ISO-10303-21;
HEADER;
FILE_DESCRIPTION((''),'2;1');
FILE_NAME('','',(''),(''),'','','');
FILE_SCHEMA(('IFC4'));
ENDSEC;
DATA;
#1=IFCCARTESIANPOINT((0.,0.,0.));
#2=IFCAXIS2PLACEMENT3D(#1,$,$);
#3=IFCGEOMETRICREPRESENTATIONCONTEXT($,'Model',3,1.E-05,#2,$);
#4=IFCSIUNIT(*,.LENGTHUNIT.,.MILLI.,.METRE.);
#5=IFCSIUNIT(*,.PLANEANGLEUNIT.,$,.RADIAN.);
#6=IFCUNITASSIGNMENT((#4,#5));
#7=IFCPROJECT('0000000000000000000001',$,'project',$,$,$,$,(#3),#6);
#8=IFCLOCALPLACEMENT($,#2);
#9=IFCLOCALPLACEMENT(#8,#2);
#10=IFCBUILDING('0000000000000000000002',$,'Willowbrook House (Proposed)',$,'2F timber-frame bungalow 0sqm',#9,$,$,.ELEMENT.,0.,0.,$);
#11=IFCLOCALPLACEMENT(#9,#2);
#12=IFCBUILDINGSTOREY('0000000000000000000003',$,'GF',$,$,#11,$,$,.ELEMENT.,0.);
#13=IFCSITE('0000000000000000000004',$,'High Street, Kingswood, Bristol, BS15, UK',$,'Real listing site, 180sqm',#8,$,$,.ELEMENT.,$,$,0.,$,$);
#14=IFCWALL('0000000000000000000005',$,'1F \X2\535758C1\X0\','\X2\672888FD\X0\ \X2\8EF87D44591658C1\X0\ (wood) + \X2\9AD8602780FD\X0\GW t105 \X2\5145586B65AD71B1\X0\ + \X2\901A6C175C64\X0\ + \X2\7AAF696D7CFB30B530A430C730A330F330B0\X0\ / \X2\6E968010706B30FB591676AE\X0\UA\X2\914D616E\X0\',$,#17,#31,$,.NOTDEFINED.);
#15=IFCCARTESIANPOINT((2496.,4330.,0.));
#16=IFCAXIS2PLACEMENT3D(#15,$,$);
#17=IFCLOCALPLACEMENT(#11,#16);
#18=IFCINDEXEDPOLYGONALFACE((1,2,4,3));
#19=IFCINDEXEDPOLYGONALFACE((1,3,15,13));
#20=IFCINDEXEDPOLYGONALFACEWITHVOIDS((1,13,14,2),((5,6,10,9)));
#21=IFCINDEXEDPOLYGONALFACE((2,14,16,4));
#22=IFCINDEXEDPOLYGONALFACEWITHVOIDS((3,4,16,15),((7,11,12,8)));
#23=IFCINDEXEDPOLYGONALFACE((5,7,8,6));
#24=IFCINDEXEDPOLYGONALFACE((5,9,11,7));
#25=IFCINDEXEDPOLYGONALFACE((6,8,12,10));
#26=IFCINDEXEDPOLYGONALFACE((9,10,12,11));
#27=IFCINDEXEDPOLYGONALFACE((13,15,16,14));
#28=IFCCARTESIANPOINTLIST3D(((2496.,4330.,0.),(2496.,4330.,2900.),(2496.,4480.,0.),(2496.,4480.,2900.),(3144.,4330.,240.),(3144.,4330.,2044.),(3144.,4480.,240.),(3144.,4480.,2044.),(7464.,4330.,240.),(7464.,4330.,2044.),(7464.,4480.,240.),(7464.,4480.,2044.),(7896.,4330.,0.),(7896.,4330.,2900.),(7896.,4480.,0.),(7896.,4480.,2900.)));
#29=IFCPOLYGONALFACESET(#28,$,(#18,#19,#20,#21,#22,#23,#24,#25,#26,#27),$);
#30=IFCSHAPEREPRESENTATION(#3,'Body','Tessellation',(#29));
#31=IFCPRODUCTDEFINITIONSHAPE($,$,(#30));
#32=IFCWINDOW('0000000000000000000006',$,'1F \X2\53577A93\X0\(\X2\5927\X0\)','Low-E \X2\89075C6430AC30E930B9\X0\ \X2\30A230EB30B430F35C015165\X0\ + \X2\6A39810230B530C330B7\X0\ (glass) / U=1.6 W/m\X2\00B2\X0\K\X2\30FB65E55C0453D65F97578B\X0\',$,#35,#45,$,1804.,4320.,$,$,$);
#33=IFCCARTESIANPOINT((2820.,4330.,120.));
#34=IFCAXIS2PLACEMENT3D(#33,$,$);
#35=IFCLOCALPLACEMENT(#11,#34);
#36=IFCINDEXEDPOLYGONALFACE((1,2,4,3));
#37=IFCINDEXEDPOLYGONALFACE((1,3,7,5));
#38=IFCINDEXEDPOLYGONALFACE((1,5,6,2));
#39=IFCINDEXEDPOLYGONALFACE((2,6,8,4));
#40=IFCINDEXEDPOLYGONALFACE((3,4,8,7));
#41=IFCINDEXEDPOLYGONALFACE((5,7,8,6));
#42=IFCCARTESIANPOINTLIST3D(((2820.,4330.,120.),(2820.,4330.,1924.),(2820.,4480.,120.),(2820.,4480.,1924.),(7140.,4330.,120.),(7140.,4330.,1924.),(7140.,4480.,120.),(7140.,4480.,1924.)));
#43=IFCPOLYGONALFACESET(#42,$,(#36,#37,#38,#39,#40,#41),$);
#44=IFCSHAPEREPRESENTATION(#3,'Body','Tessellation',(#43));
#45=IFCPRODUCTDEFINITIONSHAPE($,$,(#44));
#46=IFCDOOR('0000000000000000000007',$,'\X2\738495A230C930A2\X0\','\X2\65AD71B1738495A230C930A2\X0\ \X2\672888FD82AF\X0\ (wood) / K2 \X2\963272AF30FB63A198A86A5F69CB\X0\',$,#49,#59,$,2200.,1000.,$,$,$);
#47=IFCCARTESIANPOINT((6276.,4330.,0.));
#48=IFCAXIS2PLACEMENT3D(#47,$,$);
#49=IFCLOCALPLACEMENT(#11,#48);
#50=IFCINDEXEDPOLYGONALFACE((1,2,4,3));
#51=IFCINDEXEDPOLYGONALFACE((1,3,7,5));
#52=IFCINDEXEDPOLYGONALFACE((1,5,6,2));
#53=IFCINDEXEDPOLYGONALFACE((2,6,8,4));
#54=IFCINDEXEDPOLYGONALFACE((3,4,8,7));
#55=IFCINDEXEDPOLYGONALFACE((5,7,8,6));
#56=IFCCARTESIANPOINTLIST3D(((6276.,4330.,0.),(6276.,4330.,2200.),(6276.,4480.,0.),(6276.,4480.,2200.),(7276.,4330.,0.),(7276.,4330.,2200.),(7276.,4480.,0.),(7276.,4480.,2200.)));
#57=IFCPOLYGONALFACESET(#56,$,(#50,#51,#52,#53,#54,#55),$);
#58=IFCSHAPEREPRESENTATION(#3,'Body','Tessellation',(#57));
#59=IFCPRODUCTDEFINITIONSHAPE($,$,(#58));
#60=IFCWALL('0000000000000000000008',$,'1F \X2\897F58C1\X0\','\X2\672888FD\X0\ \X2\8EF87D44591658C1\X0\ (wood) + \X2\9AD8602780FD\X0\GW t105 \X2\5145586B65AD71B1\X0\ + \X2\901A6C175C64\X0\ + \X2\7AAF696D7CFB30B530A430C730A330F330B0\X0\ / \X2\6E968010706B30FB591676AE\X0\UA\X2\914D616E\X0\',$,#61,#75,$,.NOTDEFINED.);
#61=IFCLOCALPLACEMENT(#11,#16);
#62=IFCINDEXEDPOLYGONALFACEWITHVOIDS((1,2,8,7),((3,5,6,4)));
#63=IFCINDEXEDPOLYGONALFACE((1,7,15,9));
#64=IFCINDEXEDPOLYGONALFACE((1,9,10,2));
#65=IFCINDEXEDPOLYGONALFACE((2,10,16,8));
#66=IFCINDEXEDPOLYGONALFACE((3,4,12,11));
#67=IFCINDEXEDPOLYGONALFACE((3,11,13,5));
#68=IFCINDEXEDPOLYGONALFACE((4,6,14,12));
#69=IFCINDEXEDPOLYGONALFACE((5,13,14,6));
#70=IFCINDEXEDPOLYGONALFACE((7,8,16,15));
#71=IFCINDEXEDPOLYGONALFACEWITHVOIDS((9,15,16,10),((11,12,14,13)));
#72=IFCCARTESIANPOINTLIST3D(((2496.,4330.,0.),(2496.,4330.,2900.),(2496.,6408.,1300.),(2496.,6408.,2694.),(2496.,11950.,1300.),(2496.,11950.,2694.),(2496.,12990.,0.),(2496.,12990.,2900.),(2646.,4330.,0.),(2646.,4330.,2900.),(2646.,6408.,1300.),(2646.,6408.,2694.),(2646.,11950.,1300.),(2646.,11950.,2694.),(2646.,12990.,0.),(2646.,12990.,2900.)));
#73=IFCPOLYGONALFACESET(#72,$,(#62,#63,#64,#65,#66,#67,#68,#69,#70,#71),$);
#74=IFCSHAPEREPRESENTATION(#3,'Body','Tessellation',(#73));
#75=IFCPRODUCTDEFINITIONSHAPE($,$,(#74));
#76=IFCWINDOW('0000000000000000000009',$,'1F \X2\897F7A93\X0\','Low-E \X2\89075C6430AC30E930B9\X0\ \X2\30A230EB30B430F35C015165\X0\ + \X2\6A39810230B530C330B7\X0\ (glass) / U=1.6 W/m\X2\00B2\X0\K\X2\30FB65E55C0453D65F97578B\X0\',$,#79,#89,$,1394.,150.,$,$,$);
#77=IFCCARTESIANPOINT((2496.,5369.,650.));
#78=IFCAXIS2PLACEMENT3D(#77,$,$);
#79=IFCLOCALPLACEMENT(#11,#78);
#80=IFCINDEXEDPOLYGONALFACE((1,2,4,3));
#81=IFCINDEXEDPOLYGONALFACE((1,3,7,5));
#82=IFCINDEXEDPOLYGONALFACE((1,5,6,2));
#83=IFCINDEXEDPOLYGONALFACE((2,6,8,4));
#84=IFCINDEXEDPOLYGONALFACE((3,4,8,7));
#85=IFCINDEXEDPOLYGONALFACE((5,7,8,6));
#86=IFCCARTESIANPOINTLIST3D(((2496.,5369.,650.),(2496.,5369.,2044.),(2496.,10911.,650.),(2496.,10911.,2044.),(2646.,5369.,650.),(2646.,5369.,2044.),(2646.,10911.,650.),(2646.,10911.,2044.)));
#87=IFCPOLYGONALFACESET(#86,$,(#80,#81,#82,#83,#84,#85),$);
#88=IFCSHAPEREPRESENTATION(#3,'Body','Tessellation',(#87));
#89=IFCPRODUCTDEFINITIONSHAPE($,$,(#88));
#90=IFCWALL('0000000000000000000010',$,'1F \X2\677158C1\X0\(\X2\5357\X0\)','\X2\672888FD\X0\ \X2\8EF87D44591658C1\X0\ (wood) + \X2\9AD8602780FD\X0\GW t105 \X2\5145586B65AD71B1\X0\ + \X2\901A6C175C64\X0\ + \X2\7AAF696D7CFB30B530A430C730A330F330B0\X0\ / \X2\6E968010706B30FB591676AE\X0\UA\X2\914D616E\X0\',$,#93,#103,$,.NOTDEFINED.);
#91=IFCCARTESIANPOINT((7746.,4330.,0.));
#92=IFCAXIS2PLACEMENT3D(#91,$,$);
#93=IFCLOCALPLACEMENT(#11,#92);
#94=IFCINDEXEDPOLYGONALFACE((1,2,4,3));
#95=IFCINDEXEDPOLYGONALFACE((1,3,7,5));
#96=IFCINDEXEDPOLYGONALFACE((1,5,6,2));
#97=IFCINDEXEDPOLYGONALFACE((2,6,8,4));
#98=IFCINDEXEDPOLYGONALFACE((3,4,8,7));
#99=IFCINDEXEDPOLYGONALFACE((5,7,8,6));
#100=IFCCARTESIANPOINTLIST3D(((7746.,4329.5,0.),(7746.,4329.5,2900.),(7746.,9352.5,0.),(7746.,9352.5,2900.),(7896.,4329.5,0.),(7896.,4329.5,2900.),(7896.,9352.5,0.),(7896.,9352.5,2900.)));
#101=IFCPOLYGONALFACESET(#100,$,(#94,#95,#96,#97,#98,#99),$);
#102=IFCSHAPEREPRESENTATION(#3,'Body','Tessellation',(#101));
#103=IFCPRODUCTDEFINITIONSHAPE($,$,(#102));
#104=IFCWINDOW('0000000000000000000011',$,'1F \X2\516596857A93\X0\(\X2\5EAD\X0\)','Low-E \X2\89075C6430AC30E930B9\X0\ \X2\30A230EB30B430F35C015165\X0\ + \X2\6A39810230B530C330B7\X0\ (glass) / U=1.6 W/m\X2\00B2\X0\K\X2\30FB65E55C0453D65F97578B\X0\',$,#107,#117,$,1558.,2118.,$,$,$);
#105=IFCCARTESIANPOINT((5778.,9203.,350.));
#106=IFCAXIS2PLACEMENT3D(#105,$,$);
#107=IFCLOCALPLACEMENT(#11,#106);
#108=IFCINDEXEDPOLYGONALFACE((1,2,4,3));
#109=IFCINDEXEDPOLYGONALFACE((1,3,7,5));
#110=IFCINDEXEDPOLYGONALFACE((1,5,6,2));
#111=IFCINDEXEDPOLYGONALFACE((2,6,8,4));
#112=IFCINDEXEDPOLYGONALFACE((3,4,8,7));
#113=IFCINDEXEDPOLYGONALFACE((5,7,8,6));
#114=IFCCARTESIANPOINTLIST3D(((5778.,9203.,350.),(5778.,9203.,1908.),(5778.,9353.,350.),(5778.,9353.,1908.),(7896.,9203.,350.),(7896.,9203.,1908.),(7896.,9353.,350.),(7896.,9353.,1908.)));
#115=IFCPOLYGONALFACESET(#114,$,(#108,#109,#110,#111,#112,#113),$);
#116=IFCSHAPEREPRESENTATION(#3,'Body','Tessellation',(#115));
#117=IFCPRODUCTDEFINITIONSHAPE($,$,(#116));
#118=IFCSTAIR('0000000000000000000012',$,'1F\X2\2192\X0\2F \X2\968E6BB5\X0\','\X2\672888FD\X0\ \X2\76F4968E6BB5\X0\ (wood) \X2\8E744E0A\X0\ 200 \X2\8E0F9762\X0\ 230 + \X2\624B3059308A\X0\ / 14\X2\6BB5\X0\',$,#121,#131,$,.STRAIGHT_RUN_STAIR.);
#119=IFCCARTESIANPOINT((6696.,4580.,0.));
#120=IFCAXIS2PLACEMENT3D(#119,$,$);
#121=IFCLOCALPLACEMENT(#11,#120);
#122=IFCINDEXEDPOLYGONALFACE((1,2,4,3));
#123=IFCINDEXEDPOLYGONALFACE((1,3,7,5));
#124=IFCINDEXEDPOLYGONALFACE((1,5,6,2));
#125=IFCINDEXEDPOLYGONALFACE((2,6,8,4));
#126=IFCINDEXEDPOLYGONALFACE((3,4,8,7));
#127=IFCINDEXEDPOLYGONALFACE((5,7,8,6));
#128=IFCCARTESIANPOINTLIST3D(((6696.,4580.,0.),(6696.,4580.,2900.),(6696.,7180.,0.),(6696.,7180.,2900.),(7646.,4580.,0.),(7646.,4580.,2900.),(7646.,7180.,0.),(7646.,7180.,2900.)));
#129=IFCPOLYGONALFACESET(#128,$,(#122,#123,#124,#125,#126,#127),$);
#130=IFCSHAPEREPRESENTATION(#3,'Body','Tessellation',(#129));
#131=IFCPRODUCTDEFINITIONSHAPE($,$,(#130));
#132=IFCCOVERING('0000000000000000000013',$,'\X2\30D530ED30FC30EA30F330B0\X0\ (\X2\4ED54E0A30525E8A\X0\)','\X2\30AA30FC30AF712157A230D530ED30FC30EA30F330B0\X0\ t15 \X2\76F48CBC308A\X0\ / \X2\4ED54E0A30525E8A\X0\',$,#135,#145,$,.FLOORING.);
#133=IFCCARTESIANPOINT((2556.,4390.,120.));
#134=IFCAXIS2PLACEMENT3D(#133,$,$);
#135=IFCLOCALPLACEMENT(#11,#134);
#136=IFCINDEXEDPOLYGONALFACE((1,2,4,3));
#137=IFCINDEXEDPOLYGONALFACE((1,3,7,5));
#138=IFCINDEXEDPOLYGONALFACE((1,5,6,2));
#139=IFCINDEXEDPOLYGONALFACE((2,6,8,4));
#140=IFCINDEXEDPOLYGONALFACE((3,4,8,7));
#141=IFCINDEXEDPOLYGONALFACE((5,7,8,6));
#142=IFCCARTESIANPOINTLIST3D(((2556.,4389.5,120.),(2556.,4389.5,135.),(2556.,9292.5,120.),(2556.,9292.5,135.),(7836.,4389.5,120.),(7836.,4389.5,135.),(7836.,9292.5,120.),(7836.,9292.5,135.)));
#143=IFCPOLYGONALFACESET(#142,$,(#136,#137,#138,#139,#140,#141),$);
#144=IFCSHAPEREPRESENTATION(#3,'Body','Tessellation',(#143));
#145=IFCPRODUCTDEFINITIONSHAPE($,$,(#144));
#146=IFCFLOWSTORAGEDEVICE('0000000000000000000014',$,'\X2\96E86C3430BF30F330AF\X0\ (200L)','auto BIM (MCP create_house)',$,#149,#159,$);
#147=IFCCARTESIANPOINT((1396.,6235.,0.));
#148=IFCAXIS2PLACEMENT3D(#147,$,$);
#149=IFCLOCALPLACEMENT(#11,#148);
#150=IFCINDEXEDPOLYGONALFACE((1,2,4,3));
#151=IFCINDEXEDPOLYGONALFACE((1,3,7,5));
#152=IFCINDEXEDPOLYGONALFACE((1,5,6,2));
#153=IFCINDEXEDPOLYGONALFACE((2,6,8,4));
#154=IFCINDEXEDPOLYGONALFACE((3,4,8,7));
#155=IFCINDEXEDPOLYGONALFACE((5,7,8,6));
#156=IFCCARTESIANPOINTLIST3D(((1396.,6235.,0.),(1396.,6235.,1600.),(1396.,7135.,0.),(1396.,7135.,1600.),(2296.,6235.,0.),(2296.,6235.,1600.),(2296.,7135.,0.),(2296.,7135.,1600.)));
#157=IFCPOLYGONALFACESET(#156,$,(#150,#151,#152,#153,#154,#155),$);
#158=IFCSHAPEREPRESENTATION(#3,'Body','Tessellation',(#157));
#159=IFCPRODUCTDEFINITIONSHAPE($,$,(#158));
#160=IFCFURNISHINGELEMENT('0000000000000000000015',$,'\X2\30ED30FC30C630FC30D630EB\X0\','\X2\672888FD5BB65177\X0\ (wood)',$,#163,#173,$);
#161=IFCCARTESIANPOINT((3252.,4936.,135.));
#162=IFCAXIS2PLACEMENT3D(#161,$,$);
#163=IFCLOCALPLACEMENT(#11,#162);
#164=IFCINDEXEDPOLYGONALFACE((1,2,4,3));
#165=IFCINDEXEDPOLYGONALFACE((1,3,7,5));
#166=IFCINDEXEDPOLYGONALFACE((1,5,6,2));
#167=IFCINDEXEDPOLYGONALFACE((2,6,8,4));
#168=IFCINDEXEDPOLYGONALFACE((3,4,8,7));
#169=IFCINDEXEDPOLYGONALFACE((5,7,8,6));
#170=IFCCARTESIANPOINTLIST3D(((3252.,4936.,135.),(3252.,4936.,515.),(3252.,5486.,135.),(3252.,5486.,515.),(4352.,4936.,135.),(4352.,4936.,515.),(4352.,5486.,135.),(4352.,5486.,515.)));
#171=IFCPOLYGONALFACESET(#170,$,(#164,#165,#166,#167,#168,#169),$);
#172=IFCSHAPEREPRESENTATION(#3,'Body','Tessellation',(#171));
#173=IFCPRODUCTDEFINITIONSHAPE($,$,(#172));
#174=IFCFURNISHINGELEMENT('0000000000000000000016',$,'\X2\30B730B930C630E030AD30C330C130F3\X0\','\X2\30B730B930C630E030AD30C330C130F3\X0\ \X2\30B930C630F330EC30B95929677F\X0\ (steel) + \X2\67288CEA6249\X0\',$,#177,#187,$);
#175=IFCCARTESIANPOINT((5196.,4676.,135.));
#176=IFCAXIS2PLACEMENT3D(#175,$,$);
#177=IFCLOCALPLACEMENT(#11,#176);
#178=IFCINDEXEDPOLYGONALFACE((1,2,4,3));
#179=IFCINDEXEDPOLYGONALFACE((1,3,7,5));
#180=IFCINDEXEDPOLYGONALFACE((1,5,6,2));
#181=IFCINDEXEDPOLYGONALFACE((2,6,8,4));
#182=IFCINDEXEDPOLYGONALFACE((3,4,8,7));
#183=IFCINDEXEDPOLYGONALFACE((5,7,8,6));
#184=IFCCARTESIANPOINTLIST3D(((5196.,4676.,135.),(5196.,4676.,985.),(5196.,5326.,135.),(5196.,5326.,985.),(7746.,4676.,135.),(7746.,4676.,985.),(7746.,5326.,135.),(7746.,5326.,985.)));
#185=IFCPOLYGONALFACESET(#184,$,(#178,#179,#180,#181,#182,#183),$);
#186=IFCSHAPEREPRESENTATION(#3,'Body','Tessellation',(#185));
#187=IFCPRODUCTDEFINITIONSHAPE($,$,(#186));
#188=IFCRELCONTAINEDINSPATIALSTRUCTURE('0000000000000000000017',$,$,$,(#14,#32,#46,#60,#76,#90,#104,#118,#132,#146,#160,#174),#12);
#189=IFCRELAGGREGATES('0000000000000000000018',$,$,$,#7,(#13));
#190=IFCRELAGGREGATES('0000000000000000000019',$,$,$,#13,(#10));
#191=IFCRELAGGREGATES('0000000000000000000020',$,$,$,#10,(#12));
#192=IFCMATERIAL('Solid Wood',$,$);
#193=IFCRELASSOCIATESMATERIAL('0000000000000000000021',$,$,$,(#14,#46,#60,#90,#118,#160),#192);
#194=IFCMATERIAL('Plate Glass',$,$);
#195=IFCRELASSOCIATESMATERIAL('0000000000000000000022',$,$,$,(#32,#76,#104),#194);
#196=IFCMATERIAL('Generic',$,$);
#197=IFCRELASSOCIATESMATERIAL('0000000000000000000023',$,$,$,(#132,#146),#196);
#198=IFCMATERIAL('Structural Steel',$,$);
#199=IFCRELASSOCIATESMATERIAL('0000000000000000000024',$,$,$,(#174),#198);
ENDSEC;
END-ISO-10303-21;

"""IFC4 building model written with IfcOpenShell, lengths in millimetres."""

from ifc_helpers import new_model, si_unit, frame, frame_2d, origin, place, context, project, spatial, rectangle, extrude, material, element, fill, save


model = new_model("IFC4")

# Units and contexts
model_context = context("Model", 3, precision=1e-05, world=origin())
ifc_project = project(units=[si_unit("LENGTHUNIT", "METRE", prefix="MILLI"), si_unit("PLANEANGLEUNIT", "RADIAN")], contexts=[model_context])

# Site, building, storey
site_placement = place(None, origin())
site = spatial("IfcSite", under=ifc_project, at=site_placement, Name="High Street, Kingswood, Bristol, BS15, UK", ObjectType="Real listing site, 180sqm", CompositionType="ELEMENT", RefElevation=0.0)
building_placement = place(site_placement, origin())
building = spatial("IfcBuilding", under=site, at=building_placement, Name="Willowbrook House (Proposed)", ObjectType="2F timber-frame bungalow 0sqm", CompositionType="ELEMENT", ElevationOfRefHeight=0.0, ElevationOfTerrain=0.0)
storey_placement = place(building_placement, origin())
storey = spatial("IfcBuildingStorey", under=building, at=storey_placement, Name="GF", CompositionType="ELEMENT", Elevation=0.0)

# Shared definitions
ifc_material_1 = material(Name="Solid Wood")

# Wall, openings, window, door
wall_1_placement = place(storey_placement, frame((2496.0, 4330.0, 0.0)))
wall_1 = element("IfcWall", 1, at=wall_1_placement, inside=storey, material=ifc_material_1, Name="1F 南壁", Description="木製 軸組外壁 (wood) + 高性能GW t105 充填断熱 + 通気層 + 窯業系サイディング / 準耐火・外皮UA配慮", PredefinedType="NOTDEFINED", context=model_context, shape_type="SweptSolid", body=[
    extrude(rectangle(XDim=5400.0, YDim=150.0, at=frame_2d((2700.0, 75.0))), frame((2496.0, 4330.0, 0.0)), (0.0, 0.0, 1.0), 2900.0),
])
opening_1_placement = place(storey_placement, frame((2820.0, 4330.0, 120.0)))
opening_1 = element("IfcOpeningElement", 2, at=opening_1_placement, cuts=wall_1, PredefinedType="NOTDEFINED", context=model_context, shape_type="SweptSolid", body=[
    extrude(rectangle(XDim=4320.0, YDim=150.0, at=frame_2d((2160.0, 75.0))), frame((2820.0, 4330.0, 120.0)), (0.0, 0.0, 1.0), 1804.0),
])
opening_2_placement = place(storey_placement, frame((6276.0, 4330.0, 0.0)))
opening_2 = element("IfcOpeningElement", 3, at=opening_2_placement, cuts=wall_1, PredefinedType="NOTDEFINED", context=model_context, shape_type="SweptSolid", body=[
    extrude(rectangle(XDim=1000.0, YDim=150.0, at=frame_2d((500.0, 75.0))), frame((6276.0, 4330.0, 0.0)), (0.0, 0.0, 1.0), 2200.0),
])
ifc_material_2 = material(Name="Plate Glass")
window_1_placement = place(storey_placement, frame((2820.0, 4330.0, 120.0)))
window_1 = element("IfcWindow", 4, at=window_1_placement, inside=storey, material=ifc_material_2, Name="1F 南窓(大)", Description="Low-E 複層ガラス アルゴン封入 + 樹脂サッシ (glass) / U=1.6 W/m²K・日射取得型", OverallHeight=1804.0, OverallWidth=4320.0, context=model_context, shape_type="SweptSolid", body=[
    extrude(rectangle(XDim=4320.0, YDim=150.0, at=frame_2d((2160.0, 75.0))), frame((2820.0, 4330.0, 120.0)), (0.0, 0.0, 1.0), 1804.0),
])
fill(opening_1, window_1)
door_1_placement = place(storey_placement, frame((6276.0, 4330.0, 0.0)))
door_1 = element("IfcDoor", 5, at=door_1_placement, inside=storey, material=ifc_material_1, Name="玄関ドア", Description="断熱玄関ドア 木製芯 (wood) / K2 防犯・採風機構", OverallHeight=2200.0, OverallWidth=1000.0, context=model_context, shape_type="SweptSolid", body=[
    extrude(rectangle(XDim=1000.0, YDim=150.0, at=frame_2d((500.0, 75.0))), frame((6276.0, 4330.0, 0.0)), (0.0, 0.0, 1.0), 2200.0),
])
fill(opening_2, door_1)

# Walls, openings, windows
wall_2_placement = place(storey_placement, frame((2496.0, 4330.0, 0.0)))
wall_2 = element("IfcWall", 6, at=wall_2_placement, inside=storey, material=ifc_material_1, Name="1F 西壁", Description="木製 軸組外壁 (wood) + 高性能GW t105 充填断熱 + 通気層 + 窯業系サイディング / 準耐火・外皮UA配慮", PredefinedType="NOTDEFINED", context=model_context, shape_type="SweptSolid", body=[
    extrude(rectangle(XDim=150.0, YDim=8660.0, at=frame_2d((75.0, 4330.0))), frame((2496.0, 4330.0, 0.0)), (0.0, 0.0, 1.0), 2900.0),
])
opening_3_placement = place(storey_placement, frame((2496.0, 5369.0, 650.0)))
opening_3 = element("IfcOpeningElement", 7, at=opening_3_placement, cuts=wall_2, PredefinedType="NOTDEFINED", context=model_context, shape_type="SweptSolid", body=[
    extrude(rectangle(XDim=150.0, YDim=5542.0, at=frame_2d((75.0, 2771.0))), frame((2496.0, 5369.0, 650.0)), (0.0, 0.0, 1.0), 1394.0),
])
window_2_placement = place(storey_placement, frame((2496.0, 5369.0, 650.0)))
window_2 = element("IfcWindow", 8, at=window_2_placement, inside=storey, material=ifc_material_2, Name="1F 西窓", Description="Low-E 複層ガラス アルゴン封入 + 樹脂サッシ (glass) / U=1.6 W/m²K・日射取得型", OverallHeight=1394.0, OverallWidth=150.0, context=model_context, shape_type="SweptSolid", body=[
    extrude(rectangle(XDim=150.0, YDim=5542.0, at=frame_2d((75.0, 2771.0))), frame((2496.0, 5369.0, 650.0)), (0.0, 0.0, 1.0), 1394.0),
])
fill(opening_3, window_2)
wall_3_placement = place(storey_placement, frame((7746.0, 4330.0, 0.0)))
wall_3 = element("IfcWall", 9, at=wall_3_placement, inside=storey, material=ifc_material_1, Name="1F 東壁(南)", Description="木製 軸組外壁 (wood) + 高性能GW t105 充填断熱 + 通気層 + 窯業系サイディング / 準耐火・外皮UA配慮", PredefinedType="NOTDEFINED", context=model_context, shape_type="SweptSolid", body=[
    extrude(rectangle(XDim=150.0, YDim=5023.0, at=frame_2d((75.0, 2511.0))), frame((7746.0, 4330.0, 0.0)), (0.0, 0.0, 1.0), 2900.0),
])
opening_4_placement = place(storey_placement, frame((5778.0, 9203.0, 350.0)))
opening_4 = element("IfcOpeningElement", 10, at=opening_4_placement, cuts=wall_3, PredefinedType="NOTDEFINED", context=model_context, shape_type="SweptSolid", body=[
    extrude(rectangle(XDim=2118.0, YDim=150.0, at=frame_2d((1059.0, 75.0))), frame((5778.0, 9203.0, 350.0)), (0.0, 0.0, 1.0), 1558.0),
])
window_3_placement = place(storey_placement, frame((5778.0, 9203.0, 350.0)))
window_3 = element("IfcWindow", 11, at=window_3_placement, inside=storey, material=ifc_material_2, Name="1F 入隅窓(庭)", Description="Low-E 複層ガラス アルゴン封入 + 樹脂サッシ (glass) / U=1.6 W/m²K・日射取得型", OverallHeight=1558.0, OverallWidth=2118.0, context=model_context, shape_type="SweptSolid", body=[
    extrude(rectangle(XDim=2118.0, YDim=150.0, at=frame_2d((1059.0, 75.0))), frame((5778.0, 9203.0, 350.0)), (0.0, 0.0, 1.0), 1558.0),
])
fill(opening_4, window_3)

# Stair
stair_placement = place(storey_placement, frame((6696.0, 4580.0, 0.0)))
element("IfcStair", 12, at=stair_placement, inside=storey, material=ifc_material_1, Name="1F→2F 階段", Description="木製 直階段 (wood) 蹴上 200 踏面 230 + 手すり / 14段", PredefinedType="STRAIGHT_RUN_STAIR", context=model_context, shape_type="SweptSolid", body=[
    extrude(rectangle(XDim=950.0, YDim=2600.0, at=frame_2d((475.0, 1300.0))), frame((6696.0, 4580.0, 0.0)), (0.0, 0.0, 1.0), 2900.0),
])

# Covering
ifc_material_3 = material(Name="Generic")
covering_placement = place(storey_placement, frame((2556.0, 4390.0, 120.0)))
element("IfcCovering", 13, at=covering_placement, inside=storey, material=ifc_material_3, Name="フローリング (仕上げ床)", Description="オーク無垢フローリング t15 直貼り / 仕上げ床", PredefinedType="FLOORING", context=model_context, shape_type="SweptSolid", body=[
    extrude(rectangle(XDim=5280.0, YDim=4903.0, at=frame_2d((2640.0, 2451.0))), frame((2556.0, 4390.0, 120.0)), (0.0, 0.0, 1.0), 15.0),
])

# Flow storage device
flow_storage_device_placement = place(storey_placement, frame((1396.0, 6235.0, 0.0)))
element("IfcFlowStorageDevice", 14, at=flow_storage_device_placement, inside=storey, material=ifc_material_3, Name="雨水タンク (200L)", Description="auto BIM (MCP create_house)", context=model_context, shape_type="SweptSolid", body=[
    extrude(rectangle(XDim=900.0, YDim=900.0, at=frame_2d((450.0, 450.0))), frame((1396.0, 6235.0, 0.0)), (0.0, 0.0, 1.0), 1600.0),
])

# Furnishing elements
furnishing_1_placement = place(storey_placement, frame((3252.0, 4936.0, 135.0)))
element("IfcFurnishingElement", 15, at=furnishing_1_placement, inside=storey, material=ifc_material_1, Name="ローテーブル", Description="木製家具 (wood)", context=model_context, shape_type="SweptSolid", body=[
    extrude(rectangle(XDim=1100.0, YDim=550.0, at=frame_2d((550.0, 275.0))), frame((3252.0, 4936.0, 135.0)), (0.0, 0.0, 1.0), 380.0),
])
ifc_material_4 = material(Name="Structural Steel")
furnishing_2_placement = place(storey_placement, frame((5196.0, 4676.0, 135.0)))
element("IfcFurnishingElement", 16, at=furnishing_2_placement, inside=storey, material=ifc_material_4, Name="システムキッチン", Description="システムキッチン ステンレス天板 (steel) + 木質扉", context=model_context, shape_type="SweptSolid", body=[
    extrude(rectangle(XDim=2550.0, YDim=650.0, at=frame_2d((1275.0, 325.0))), frame((5196.0, 4676.0, 135.0)), (0.0, 0.0, 1.0), 850.0),
])

save(model, "model.ifc")
